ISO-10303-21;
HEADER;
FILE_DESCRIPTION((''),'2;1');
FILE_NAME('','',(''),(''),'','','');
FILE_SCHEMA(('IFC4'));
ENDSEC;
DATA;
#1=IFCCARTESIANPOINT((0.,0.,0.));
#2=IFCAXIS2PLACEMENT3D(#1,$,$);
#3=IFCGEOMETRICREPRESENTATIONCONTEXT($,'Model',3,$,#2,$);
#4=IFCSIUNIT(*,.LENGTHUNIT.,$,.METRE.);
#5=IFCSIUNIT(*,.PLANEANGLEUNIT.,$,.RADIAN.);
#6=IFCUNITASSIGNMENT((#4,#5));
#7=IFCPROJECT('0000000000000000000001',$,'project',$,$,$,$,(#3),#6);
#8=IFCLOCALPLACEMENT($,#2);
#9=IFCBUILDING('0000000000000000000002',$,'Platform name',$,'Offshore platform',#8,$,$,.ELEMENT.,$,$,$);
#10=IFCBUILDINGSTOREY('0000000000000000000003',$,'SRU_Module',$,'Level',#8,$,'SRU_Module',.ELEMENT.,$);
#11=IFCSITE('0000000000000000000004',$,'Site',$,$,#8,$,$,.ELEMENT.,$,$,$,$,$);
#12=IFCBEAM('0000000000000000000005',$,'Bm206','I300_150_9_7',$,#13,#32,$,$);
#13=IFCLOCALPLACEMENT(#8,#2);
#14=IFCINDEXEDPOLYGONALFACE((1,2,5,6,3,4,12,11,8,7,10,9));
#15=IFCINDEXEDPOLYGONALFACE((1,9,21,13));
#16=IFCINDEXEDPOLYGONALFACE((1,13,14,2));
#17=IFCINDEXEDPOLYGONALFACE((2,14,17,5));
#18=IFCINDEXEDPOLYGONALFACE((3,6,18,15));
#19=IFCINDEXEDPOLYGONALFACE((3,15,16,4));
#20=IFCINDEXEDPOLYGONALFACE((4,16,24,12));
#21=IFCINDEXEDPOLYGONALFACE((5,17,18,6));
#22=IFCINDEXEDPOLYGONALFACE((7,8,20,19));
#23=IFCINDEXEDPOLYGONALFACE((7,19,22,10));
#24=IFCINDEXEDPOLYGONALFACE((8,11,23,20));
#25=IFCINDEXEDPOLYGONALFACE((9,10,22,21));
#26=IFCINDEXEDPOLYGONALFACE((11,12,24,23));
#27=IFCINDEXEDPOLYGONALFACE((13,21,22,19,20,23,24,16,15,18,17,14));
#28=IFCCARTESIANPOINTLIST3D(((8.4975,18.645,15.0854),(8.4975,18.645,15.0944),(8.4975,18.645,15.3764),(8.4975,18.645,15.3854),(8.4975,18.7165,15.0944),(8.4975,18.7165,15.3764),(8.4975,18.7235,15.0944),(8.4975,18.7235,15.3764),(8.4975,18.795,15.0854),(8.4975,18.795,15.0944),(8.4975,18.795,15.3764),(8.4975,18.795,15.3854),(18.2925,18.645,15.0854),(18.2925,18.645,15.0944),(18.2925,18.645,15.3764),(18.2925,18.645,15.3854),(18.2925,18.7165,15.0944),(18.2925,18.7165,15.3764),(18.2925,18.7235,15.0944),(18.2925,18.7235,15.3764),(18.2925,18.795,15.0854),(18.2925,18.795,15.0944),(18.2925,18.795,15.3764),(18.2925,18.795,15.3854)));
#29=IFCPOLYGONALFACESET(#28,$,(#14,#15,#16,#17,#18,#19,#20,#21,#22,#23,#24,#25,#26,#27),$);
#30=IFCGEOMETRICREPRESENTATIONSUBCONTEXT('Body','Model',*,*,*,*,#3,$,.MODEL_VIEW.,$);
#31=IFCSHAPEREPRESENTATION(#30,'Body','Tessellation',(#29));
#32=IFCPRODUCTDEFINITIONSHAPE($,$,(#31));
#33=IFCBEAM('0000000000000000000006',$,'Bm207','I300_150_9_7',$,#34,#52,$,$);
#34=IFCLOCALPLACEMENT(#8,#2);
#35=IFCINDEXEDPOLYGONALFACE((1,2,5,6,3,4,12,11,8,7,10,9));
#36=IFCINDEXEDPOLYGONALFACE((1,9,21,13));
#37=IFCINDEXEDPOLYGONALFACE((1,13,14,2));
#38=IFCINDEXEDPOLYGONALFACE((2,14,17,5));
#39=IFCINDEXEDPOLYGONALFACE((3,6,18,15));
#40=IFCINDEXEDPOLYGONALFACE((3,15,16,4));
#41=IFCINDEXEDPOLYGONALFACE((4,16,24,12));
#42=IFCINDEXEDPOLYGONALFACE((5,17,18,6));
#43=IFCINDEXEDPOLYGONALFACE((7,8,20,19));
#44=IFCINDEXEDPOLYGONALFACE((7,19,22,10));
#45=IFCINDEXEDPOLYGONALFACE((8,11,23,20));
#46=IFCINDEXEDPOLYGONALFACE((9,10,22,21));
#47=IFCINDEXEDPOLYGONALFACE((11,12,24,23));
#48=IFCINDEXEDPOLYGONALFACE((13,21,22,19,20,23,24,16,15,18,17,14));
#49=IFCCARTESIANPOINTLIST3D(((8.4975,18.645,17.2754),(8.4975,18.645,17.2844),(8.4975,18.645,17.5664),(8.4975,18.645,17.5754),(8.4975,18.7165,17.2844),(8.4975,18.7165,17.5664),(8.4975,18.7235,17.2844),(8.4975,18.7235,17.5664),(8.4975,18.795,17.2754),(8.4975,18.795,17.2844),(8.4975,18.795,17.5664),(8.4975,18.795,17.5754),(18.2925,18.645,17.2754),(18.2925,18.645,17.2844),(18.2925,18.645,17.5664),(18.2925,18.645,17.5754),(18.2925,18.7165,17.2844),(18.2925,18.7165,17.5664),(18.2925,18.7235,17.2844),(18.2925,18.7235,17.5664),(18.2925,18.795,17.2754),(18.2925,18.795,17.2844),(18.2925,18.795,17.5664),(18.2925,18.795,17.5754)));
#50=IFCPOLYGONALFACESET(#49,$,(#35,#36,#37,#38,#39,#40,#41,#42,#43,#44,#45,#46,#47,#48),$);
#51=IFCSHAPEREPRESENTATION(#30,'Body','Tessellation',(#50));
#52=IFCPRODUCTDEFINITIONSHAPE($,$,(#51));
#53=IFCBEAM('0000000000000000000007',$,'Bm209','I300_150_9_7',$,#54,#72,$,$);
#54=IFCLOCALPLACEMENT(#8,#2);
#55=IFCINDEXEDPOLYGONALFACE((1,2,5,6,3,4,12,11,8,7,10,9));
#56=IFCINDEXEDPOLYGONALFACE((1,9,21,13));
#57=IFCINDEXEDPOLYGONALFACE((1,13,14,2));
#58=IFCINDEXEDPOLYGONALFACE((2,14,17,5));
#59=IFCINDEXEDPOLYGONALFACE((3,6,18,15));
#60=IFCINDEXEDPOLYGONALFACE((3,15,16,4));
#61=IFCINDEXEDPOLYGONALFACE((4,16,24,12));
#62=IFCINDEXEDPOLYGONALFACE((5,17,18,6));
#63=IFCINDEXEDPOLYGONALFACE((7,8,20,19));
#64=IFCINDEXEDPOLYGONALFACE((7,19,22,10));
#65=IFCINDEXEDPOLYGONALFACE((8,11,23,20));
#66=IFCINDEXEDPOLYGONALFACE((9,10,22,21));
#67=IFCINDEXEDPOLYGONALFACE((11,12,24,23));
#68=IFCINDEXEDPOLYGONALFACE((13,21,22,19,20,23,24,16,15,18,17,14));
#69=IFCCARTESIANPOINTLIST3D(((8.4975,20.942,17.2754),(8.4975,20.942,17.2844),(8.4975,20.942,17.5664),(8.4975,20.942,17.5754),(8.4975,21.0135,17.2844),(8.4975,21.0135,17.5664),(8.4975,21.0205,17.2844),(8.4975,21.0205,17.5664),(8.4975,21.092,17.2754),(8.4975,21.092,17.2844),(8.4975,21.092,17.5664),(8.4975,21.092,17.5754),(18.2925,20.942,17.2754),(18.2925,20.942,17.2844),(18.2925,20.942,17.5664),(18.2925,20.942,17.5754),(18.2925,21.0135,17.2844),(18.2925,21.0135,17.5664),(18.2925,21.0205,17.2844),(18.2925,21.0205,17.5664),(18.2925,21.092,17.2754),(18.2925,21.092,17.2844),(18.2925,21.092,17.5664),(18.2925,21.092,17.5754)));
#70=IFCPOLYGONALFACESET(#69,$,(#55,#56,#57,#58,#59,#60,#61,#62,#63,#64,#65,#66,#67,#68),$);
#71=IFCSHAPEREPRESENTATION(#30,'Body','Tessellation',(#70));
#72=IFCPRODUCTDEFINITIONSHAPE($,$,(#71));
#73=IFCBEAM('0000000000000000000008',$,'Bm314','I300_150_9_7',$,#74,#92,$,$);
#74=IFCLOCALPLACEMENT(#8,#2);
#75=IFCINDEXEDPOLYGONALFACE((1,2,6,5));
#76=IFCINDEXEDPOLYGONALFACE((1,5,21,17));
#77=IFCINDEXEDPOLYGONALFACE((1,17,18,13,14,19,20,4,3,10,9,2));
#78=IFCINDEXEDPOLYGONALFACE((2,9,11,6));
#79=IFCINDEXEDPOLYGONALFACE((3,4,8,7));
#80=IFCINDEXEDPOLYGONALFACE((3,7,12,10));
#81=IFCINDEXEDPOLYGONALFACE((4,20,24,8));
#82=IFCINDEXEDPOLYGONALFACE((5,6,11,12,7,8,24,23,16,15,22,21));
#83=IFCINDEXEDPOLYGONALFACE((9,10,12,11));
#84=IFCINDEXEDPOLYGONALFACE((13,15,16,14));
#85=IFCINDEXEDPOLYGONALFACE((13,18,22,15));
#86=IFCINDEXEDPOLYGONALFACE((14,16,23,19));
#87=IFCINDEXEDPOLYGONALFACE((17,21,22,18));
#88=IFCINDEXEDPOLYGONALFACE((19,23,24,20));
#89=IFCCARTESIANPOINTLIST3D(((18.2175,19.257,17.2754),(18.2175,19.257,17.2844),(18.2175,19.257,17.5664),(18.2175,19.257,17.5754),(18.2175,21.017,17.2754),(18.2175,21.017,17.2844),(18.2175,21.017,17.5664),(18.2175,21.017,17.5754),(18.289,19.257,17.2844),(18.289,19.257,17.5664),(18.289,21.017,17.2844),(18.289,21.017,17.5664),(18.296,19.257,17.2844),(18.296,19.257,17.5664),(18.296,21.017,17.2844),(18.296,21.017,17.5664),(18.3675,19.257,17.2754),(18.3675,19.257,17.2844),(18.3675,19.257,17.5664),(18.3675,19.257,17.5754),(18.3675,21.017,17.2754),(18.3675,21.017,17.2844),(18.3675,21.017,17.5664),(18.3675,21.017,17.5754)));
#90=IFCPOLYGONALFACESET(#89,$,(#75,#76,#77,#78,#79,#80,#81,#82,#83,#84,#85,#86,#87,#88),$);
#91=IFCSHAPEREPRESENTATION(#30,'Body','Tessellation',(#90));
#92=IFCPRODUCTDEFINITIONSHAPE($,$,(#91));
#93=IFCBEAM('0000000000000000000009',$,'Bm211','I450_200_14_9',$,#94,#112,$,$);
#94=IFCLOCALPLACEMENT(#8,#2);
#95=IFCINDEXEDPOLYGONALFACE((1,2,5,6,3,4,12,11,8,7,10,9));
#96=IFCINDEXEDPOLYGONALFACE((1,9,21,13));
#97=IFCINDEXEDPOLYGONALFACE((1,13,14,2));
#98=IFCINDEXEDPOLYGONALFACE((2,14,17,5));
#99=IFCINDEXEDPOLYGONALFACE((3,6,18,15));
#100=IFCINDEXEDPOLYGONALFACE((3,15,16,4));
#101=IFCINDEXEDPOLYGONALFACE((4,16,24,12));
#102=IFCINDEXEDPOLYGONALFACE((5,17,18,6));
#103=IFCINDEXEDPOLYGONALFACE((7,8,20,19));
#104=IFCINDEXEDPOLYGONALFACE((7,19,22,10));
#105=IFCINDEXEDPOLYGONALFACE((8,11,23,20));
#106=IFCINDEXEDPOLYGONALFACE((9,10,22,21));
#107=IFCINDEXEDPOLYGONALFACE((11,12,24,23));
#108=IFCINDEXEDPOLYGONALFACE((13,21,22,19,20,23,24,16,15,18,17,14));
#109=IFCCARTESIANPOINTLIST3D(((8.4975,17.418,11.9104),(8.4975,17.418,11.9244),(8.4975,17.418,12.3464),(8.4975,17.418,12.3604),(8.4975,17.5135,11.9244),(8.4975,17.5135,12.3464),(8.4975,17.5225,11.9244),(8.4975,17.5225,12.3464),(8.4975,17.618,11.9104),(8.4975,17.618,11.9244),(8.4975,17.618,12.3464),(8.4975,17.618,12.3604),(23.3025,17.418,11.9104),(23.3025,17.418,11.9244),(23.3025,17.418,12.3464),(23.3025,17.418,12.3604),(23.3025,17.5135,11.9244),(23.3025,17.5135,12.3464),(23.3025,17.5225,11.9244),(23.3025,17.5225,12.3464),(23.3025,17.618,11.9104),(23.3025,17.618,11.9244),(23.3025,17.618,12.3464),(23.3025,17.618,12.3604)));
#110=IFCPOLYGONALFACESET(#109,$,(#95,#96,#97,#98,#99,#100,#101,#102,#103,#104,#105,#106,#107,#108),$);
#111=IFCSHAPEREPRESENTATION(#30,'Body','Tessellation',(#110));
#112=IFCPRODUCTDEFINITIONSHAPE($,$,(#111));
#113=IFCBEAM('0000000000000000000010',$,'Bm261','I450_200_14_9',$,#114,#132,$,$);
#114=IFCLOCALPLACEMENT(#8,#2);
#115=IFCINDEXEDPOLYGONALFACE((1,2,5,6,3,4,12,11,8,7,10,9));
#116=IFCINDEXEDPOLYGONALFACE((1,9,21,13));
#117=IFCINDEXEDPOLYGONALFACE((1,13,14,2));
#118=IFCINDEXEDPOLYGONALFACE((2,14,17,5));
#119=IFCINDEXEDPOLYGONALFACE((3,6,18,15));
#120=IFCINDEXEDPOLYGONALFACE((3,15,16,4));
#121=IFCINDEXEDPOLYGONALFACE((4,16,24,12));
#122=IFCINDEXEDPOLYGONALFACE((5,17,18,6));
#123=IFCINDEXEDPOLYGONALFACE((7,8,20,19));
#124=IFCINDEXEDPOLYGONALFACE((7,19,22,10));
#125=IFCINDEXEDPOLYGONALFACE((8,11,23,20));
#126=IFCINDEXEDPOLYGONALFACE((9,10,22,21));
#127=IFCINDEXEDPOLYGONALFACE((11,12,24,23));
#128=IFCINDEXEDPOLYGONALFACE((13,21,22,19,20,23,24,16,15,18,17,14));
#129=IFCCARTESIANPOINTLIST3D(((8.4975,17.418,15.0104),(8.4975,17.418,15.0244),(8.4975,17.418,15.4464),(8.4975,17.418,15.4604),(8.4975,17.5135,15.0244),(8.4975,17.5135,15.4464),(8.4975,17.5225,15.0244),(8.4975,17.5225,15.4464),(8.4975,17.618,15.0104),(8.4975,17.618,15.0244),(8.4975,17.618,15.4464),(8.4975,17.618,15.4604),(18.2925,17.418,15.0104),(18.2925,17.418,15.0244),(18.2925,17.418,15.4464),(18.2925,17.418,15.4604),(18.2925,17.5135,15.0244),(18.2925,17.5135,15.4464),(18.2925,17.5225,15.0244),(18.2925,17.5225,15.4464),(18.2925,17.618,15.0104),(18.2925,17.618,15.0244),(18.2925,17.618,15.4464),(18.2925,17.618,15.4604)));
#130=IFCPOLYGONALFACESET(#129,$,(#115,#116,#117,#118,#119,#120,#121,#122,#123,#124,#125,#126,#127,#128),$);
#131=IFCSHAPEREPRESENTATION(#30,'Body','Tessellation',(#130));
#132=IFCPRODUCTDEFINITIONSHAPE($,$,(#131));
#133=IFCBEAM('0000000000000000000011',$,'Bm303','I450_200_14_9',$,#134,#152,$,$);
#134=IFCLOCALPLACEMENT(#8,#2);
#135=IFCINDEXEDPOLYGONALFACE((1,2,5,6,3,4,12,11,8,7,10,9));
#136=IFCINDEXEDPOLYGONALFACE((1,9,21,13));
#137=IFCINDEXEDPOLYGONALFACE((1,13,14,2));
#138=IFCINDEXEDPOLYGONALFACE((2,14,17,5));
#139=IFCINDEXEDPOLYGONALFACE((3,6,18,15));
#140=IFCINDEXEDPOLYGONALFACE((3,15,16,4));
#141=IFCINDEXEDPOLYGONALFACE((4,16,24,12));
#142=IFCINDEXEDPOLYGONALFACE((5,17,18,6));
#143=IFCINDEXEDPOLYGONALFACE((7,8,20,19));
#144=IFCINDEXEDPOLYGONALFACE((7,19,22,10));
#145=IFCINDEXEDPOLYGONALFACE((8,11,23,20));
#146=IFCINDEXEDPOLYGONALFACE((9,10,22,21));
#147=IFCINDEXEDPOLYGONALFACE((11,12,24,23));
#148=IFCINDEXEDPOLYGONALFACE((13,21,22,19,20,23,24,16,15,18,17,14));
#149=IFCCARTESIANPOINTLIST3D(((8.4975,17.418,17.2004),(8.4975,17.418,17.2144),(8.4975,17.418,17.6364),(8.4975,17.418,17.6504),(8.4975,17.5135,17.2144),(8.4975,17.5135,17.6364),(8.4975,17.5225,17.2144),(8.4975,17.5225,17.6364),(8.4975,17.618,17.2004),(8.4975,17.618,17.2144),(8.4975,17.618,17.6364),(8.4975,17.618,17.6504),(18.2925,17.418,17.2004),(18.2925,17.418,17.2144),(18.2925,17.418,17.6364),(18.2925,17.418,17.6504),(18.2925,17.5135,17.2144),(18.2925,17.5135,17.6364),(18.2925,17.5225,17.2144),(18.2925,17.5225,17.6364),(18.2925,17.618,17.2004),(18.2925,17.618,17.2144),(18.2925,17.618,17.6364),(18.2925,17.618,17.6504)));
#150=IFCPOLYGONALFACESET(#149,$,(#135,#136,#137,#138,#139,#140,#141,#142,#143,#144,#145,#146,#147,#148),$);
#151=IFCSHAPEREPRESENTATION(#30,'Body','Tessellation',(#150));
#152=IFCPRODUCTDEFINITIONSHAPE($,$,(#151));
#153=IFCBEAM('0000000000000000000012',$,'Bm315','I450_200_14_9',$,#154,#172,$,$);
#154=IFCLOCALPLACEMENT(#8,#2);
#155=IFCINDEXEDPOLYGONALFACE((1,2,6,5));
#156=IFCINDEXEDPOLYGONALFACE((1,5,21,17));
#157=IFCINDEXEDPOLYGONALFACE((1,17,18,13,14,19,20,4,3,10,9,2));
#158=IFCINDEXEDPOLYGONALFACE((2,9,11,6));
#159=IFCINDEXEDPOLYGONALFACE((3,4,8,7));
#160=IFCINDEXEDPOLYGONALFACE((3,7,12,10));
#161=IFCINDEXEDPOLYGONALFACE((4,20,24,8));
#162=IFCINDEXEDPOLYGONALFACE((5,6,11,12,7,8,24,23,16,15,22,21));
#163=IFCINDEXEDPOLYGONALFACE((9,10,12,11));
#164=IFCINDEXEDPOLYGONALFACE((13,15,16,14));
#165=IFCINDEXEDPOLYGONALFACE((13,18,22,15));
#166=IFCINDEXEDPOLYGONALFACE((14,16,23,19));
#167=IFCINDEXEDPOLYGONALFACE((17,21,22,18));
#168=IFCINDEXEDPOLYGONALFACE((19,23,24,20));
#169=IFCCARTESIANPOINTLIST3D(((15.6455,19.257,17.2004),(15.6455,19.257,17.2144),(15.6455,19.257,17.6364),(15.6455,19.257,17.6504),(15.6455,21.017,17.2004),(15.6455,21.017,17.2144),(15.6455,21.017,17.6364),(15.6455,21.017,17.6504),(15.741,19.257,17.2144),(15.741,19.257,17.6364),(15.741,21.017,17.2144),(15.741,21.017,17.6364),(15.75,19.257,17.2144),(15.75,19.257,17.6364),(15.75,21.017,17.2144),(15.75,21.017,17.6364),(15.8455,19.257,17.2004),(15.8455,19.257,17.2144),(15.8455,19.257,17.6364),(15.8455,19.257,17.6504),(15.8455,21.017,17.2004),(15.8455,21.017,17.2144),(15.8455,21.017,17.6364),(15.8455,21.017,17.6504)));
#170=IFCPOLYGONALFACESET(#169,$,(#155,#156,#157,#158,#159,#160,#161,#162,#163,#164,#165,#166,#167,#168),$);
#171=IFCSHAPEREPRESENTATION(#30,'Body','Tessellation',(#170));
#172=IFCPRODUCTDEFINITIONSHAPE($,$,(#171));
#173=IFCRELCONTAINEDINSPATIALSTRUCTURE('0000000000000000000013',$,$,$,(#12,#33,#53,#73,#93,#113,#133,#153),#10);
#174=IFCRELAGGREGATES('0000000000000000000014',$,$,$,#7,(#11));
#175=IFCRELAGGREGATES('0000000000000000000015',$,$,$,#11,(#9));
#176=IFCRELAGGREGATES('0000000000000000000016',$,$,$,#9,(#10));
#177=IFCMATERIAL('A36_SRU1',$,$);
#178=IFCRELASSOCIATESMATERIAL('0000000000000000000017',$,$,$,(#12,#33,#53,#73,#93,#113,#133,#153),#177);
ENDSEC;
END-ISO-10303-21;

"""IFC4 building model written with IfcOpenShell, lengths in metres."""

from ifc_helpers import new_model, si_unit, frame, origin, origin_2d, place, context, subcontext, project, spatial, i_section, extrude, source, transform, mapped, material, element, save


model = new_model("IFC4")

# Units and contexts
model_context = context("Model", 3, world=origin())
body_context = subcontext(model_context, "Body", "Model", "MODEL_VIEW")
ifc_project = project(units=[si_unit("LENGTHUNIT", "METRE"), si_unit("PLANEANGLEUNIT", "RADIAN")], contexts=[model_context])

# Site, building, storey
placement_1 = place(None, origin())
site = spatial("IfcSite", under=ifc_project, at=placement_1, Name="Site", CompositionType="ELEMENT")
building = spatial("IfcBuilding", under=site, at=placement_1, Name="Platform name", ObjectType="Offshore platform", CompositionType="ELEMENT")
storey = spatial("IfcBuildingStorey", under=building, at=placement_1, Name="SRU_Module", ObjectType="Level", LongName="SRU_Module", CompositionType="ELEMENT")

# Beams
ifc_material_1 = material(Name="A36_SRU1")
shared_shape_1 = source(origin(), body_context, "Body", "SweptSolid", [
    extrude(i_section(OverallWidth=0.15, OverallDepth=0.3, WebThickness=0.007, FlangeThickness=0.009, FilletRadius=0.0, at=origin_2d()), frame((0.0, 0.0, 0.0), z_axis=(-1.0, 0.0, 0.0), x_axis=(0.0, -1.0, 0.0)), (0.0, 0.0, 1.0), 9.795),
])
placement_2 = place(None, origin())
placement_3 = place(placement_2, origin())
placement_4 = place(placement_3, origin())
beam_1_placement = place(placement_4, frame((18.2925, 18.72, 15.2354)))
element("IfcBeam", 1, at=beam_1_placement, inside=storey, material=ifc_material_1, Name="Bm206", Description="I300_150_9_7", context=body_context, shape_type="MappedRepresentation", body=[
    mapped(shared_shape_1, transform((0.0, 0.0, 0.0), scale=1.0)),
])
shared_shape_2 = source(origin(), body_context, "Body", "SweptSolid", [
    extrude(i_section(OverallWidth=0.15, OverallDepth=0.3, WebThickness=0.007, FlangeThickness=0.009, FilletRadius=0.0, at=origin_2d()), frame((0.0, 0.0, 0.0), z_axis=(-1.0, 0.0, 0.0), x_axis=(0.0, -1.0, 0.0)), (0.0, 0.0, 1.0), 9.795),
])
placement_5 = place(None, origin())
placement_6 = place(placement_5, origin())
placement_7 = place(placement_6, origin())
beam_2_placement = place(placement_7, frame((18.2925, 18.72, 17.4254)))
element("IfcBeam", 2, at=beam_2_placement, inside=storey, material=ifc_material_1, Name="Bm207", Description="I300_150_9_7", context=body_context, shape_type="MappedRepresentation", body=[
    mapped(shared_shape_2, transform((0.0, 0.0, 0.0), scale=1.0)),
])
shared_shape_3 = source(origin(), body_context, "Body", "SweptSolid", [
    extrude(i_section(OverallWidth=0.15, OverallDepth=0.3, WebThickness=0.007, FlangeThickness=0.009, FilletRadius=0.0, at=origin_2d()), frame((0.0, 0.0, 0.0), z_axis=(-1.0, 0.0, 0.0), x_axis=(0.0, -1.0, 0.0)), (0.0, 0.0, 1.0), 9.795),
])
placement_8 = place(None, origin())
placement_9 = place(placement_8, origin())
placement_10 = place(placement_9, origin())
beam_3_placement = place(placement_10, frame((18.2925, 21.017, 17.4254)))
element("IfcBeam", 3, at=beam_3_placement, inside=storey, material=ifc_material_1, Name="Bm209", Description="I300_150_9_7", context=body_context, shape_type="MappedRepresentation", body=[
    mapped(shared_shape_3, transform((0.0, 0.0, 0.0), scale=1.0)),
])
shared_shape_4 = source(origin(), body_context, "Body", "SweptSolid", [
    extrude(i_section(OverallWidth=0.15, OverallDepth=0.3, WebThickness=0.007, FlangeThickness=0.009, FilletRadius=0.0, at=origin_2d()), frame((0.0, 0.0, 0.0), z_axis=(0.0, 1.0, 0.0), x_axis=(-1.0, 0.0, 0.0)), (0.0, 0.0, 1.0), 1.76),
])
placement_11 = place(None, origin())
placement_12 = place(placement_11, origin())
placement_13 = place(placement_12, origin())
beam_4_placement = place(placement_13, frame((18.2925, 19.257, 17.4254)))
element("IfcBeam", 4, at=beam_4_placement, inside=storey, material=ifc_material_1, Name="Bm314", Description="I300_150_9_7", context=body_context, shape_type="MappedRepresentation", body=[
    mapped(shared_shape_4, transform((0.0, 0.0, 0.0), scale=1.0)),
])
shared_shape_5 = source(origin(), body_context, "Body", "SweptSolid", [
    extrude(i_section(OverallWidth=0.2, OverallDepth=0.45, WebThickness=0.009, FlangeThickness=0.014, FilletRadius=0.0, at=origin_2d()), frame((0.0, 0.0, 0.0), z_axis=(-1.0, 0.0, 0.0), x_axis=(0.0, -1.0, 0.0)), (0.0, 0.0, 1.0), 14.805),
])
placement_14 = place(None, origin())
placement_15 = place(placement_14, origin())
placement_16 = place(placement_15, origin())
beam_5_placement = place(placement_16, frame((23.3025, 17.518, 12.1354)))
element("IfcBeam", 5, at=beam_5_placement, inside=storey, material=ifc_material_1, Name="Bm211", Description="I450_200_14_9", context=body_context, shape_type="MappedRepresentation", body=[
    mapped(shared_shape_5, transform((0.0, 0.0, 0.0), scale=1.0)),
])
shared_shape_6 = source(origin(), body_context, "Body", "SweptSolid", [
    extrude(i_section(OverallWidth=0.2, OverallDepth=0.45, WebThickness=0.009, FlangeThickness=0.014, FilletRadius=0.0, at=origin_2d()), frame((0.0, 0.0, 0.0), z_axis=(-1.0, 0.0, 0.0), x_axis=(0.0, -1.0, 0.0)), (0.0, 0.0, 1.0), 9.795),
])
placement_17 = place(None, origin())
placement_18 = place(placement_17, origin())
placement_19 = place(placement_18, origin())
beam_6_placement = place(placement_19, frame((18.2925, 17.518, 15.2354)))
element("IfcBeam", 6, at=beam_6_placement, inside=storey, material=ifc_material_1, Name="Bm261", Description="I450_200_14_9", context=body_context, shape_type="MappedRepresentation", body=[
    mapped(shared_shape_6, transform((0.0, 0.0, 0.0), scale=1.0)),
])
shared_shape_7 = source(origin(), body_context, "Body", "SweptSolid", [
    extrude(i_section(OverallWidth=0.2, OverallDepth=0.45, WebThickness=0.009, FlangeThickness=0.014, FilletRadius=0.0, at=origin_2d()), frame((0.0, 0.0, 0.0), z_axis=(-1.0, 0.0, 0.0), x_axis=(0.0, -1.0, 0.0)), (0.0, 0.0, 1.0), 9.795),
])
placement_20 = place(None, origin())
placement_21 = place(placement_20, origin())
placement_22 = place(placement_21, origin())
beam_7_placement = place(placement_22, frame((18.2925, 17.518, 17.4254)))
element("IfcBeam", 7, at=beam_7_placement, inside=storey, material=ifc_material_1, Name="Bm303", Description="I450_200_14_9", context=body_context, shape_type="MappedRepresentation", body=[
    mapped(shared_shape_7, transform((0.0, 0.0, 0.0), scale=1.0)),
])
shared_shape_8 = source(origin(), body_context, "Body", "SweptSolid", [
    extrude(i_section(OverallWidth=0.2, OverallDepth=0.45, WebThickness=0.009, FlangeThickness=0.014, FilletRadius=0.0, at=origin_2d()), frame((0.0, 0.0, 0.0), z_axis=(0.0, 1.0, 0.0), x_axis=(-1.0, 0.0, 0.0)), (0.0, 0.0, 1.0), 1.76),
])
placement_23 = place(None, origin())
placement_24 = place(placement_23, origin())
placement_25 = place(placement_24, origin())
beam_8_placement = place(placement_25, frame((15.7455, 19.257, 17.4254)))
element("IfcBeam", 8, at=beam_8_placement, inside=storey, material=ifc_material_1, Name="Bm315", Description="I450_200_14_9", context=body_context, shape_type="MappedRepresentation", body=[
    mapped(shared_shape_8, transform((0.0, 0.0, 0.0), scale=1.0)),
])

save(model, "model.ifc")
